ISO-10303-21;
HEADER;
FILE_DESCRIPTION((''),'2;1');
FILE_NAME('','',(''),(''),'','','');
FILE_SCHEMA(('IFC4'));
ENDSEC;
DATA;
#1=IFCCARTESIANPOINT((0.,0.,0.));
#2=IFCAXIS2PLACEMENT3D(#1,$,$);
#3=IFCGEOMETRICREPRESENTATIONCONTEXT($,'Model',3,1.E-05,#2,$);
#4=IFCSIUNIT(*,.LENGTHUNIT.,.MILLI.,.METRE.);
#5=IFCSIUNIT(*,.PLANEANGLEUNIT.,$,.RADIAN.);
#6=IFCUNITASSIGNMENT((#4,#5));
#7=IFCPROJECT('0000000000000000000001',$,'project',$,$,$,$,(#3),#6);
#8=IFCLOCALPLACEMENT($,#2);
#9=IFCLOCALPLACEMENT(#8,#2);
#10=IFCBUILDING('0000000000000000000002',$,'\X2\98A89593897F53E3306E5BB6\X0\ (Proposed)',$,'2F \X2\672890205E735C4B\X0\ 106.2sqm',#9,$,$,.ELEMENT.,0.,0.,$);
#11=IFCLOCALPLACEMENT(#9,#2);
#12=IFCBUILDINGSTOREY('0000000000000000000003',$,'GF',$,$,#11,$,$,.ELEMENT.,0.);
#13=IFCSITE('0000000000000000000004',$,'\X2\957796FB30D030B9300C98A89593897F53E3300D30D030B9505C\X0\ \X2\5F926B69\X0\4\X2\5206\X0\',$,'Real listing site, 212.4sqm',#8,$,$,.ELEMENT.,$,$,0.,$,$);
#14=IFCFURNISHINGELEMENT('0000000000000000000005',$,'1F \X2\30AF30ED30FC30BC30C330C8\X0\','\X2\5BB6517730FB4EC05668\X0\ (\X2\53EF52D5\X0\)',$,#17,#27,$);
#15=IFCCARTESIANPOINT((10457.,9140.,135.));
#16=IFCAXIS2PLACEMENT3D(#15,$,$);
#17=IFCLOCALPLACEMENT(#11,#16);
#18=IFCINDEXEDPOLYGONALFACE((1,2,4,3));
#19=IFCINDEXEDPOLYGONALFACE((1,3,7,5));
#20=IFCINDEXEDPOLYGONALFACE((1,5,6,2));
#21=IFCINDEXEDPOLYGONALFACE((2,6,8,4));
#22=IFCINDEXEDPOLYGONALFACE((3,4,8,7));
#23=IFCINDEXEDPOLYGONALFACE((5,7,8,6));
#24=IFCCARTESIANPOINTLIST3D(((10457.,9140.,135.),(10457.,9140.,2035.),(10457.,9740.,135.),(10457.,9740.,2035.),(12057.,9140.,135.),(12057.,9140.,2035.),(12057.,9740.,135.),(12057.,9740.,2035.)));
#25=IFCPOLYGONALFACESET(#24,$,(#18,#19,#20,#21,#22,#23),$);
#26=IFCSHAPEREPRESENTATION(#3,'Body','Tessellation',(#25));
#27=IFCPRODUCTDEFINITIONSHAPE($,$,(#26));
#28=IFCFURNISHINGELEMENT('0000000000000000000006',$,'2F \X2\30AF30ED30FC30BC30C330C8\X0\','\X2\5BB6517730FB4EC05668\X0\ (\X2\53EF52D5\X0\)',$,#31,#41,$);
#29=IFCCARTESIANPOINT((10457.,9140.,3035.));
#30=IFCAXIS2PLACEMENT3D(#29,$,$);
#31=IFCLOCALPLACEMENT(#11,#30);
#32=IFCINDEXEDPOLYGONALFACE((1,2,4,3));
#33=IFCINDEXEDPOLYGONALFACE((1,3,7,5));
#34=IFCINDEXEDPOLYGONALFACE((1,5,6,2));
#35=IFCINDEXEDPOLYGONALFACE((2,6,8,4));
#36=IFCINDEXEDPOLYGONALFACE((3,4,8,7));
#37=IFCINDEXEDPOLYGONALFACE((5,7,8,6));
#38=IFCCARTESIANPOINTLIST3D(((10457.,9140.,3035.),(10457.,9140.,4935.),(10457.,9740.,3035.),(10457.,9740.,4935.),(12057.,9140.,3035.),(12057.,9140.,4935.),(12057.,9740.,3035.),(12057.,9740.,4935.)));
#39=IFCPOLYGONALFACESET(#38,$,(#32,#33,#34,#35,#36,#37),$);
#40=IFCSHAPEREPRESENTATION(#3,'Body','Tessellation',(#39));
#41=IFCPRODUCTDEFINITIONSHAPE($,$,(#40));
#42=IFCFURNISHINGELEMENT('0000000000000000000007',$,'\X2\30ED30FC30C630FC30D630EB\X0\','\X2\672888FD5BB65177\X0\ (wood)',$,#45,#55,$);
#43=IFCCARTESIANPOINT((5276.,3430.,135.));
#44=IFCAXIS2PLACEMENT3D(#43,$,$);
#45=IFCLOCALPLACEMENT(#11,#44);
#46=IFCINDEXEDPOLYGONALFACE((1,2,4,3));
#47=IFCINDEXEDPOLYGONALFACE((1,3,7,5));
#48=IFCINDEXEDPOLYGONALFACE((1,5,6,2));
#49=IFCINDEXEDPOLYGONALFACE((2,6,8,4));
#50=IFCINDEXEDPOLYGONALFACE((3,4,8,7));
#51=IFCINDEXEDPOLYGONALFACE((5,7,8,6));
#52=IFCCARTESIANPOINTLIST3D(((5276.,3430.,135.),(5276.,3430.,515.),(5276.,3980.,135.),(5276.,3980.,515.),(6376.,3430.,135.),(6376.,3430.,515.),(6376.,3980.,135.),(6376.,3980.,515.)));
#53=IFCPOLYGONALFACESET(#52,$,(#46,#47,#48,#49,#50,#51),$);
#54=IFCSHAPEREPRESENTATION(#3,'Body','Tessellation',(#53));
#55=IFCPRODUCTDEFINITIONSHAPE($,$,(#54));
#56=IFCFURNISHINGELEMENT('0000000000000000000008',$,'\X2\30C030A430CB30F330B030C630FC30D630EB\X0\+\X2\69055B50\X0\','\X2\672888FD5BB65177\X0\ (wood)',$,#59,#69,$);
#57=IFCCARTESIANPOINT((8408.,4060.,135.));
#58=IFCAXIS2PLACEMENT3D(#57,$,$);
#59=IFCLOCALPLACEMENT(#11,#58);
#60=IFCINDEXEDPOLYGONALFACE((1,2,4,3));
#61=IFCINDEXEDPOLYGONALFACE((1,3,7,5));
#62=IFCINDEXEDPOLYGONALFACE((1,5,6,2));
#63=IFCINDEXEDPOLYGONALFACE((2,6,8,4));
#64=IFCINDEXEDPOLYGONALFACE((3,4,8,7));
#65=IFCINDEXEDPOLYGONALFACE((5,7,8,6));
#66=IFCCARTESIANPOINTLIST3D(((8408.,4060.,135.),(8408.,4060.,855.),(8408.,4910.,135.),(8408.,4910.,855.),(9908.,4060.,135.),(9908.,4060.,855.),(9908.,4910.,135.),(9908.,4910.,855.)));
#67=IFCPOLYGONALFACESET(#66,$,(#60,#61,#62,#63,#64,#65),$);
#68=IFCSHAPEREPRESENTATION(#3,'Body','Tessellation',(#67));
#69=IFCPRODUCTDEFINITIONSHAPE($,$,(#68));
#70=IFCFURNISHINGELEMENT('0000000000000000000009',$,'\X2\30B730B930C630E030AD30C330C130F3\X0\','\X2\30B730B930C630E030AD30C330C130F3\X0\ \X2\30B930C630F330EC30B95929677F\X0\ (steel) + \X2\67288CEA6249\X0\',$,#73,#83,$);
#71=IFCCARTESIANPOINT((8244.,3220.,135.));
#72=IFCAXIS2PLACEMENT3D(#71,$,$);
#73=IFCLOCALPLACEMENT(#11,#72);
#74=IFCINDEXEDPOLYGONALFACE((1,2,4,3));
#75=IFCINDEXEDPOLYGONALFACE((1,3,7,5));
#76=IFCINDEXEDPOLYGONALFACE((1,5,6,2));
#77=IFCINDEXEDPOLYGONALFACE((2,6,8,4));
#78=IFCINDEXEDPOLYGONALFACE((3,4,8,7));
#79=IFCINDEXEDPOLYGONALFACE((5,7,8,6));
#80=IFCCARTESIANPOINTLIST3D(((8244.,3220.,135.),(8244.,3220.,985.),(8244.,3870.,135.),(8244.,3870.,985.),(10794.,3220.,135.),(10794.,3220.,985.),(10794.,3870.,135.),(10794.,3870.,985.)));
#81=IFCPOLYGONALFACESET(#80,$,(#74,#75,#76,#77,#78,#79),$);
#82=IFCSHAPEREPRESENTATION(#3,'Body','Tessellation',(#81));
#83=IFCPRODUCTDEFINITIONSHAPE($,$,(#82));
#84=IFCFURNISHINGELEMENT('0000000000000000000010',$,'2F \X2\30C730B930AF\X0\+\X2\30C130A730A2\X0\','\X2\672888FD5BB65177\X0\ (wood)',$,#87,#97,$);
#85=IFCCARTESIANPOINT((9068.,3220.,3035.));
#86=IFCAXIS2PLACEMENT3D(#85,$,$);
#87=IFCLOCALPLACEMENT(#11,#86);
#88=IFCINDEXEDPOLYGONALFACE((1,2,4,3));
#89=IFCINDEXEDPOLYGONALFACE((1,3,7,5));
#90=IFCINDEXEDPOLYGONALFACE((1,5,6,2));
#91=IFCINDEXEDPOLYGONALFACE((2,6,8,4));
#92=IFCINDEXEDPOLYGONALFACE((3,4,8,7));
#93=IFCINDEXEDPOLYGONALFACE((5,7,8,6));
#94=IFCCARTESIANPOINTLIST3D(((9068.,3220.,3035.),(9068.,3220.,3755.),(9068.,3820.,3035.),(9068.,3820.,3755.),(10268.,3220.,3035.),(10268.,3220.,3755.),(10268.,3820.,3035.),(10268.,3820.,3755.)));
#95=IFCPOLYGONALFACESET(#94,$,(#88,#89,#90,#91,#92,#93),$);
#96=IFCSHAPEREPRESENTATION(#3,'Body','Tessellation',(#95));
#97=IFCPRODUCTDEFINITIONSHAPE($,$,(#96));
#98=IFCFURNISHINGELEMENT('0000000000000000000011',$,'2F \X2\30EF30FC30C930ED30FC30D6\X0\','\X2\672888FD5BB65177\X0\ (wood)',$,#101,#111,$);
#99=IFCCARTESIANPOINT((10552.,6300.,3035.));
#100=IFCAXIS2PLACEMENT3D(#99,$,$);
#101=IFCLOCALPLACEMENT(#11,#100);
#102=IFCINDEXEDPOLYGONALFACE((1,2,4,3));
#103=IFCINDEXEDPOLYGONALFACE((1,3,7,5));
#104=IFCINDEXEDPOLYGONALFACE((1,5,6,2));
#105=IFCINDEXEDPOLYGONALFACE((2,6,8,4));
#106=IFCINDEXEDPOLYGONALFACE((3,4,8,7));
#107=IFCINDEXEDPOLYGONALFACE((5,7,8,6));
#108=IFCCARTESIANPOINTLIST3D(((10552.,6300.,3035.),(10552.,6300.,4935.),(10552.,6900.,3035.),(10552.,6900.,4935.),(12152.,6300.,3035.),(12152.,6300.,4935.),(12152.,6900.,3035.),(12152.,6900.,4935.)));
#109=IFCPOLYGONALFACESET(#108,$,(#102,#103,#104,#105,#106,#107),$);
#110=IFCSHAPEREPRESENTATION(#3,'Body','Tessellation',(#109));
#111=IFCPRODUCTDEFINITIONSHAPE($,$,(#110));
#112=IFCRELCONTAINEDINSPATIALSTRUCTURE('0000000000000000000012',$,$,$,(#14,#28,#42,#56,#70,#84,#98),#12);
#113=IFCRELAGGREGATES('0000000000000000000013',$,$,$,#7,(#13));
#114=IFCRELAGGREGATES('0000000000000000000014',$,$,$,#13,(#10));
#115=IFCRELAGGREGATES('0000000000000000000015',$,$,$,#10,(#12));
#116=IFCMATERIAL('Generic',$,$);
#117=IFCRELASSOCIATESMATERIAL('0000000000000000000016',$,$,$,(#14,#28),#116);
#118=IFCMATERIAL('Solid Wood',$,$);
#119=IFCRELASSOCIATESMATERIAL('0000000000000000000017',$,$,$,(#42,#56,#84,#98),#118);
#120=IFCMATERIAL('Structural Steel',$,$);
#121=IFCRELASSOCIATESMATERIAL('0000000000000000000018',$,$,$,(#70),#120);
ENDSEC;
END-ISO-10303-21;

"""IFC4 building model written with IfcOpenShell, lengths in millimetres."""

from ifc_helpers import new_model, si_unit, frame, frame_2d, origin, place, context, project, spatial, rectangle, extrude, material, element, save


model = new_model("IFC4")

# Units and contexts
model_context = context("Model", 3, precision=1e-05, world=origin())
ifc_project = project(units=[si_unit("LENGTHUNIT", "METRE", prefix="MILLI"), si_unit("PLANEANGLEUNIT", "RADIAN")], contexts=[model_context])

# Site, building, storey
site_placement = place(None, origin())
site = spatial("IfcSite", under=ifc_project, at=site_placement, Name="長電バス「風間西口」バス停 徒歩4分", ObjectType="Real listing site, 212.4sqm", CompositionType="ELEMENT", RefElevation=0.0)
building_placement = place(site_placement, origin())
building = spatial("IfcBuilding", under=site, at=building_placement, Name="風間西口の家 (Proposed)", ObjectType="2F 木造平屋 106.2sqm", CompositionType="ELEMENT", ElevationOfRefHeight=0.0, ElevationOfTerrain=0.0)
storey_placement = place(building_placement, origin())
storey = spatial("IfcBuildingStorey", under=building, at=storey_placement, Name="GF", CompositionType="ELEMENT", Elevation=0.0)

# Shared definitions
ifc_material_1 = material(Name="Solid Wood")

# Shared definitions
ifc_material_2 = material(Name="Generic")

# Furnishing elements
furnishing_1_placement = place(storey_placement, frame((10457.0, 9140.0, 135.0)))
element("IfcFurnishingElement", 1, at=furnishing_1_placement, inside=storey, material=ifc_material_2, Name="1F クローゼット", Description="家具・什器 (可動)", context=model_context, shape_type="SweptSolid", body=[
    extrude(rectangle(XDim=1600.0, YDim=600.0, at=frame_2d((800.0, 300.0))), frame((10457.0, 9140.0, 135.0)), (0.0, 0.0, 1.0), 1900.0),
])
furnishing_2_placement = place(storey_placement, frame((10457.0, 9140.0, 3035.0)))
element("IfcFurnishingElement", 2, at=furnishing_2_placement, inside=storey, material=ifc_material_2, Name="2F クローゼット", Description="家具・什器 (可動)", context=model_context, shape_type="SweptSolid", body=[
    extrude(rectangle(XDim=1600.0, YDim=600.0, at=frame_2d((800.0, 300.0))), frame((10457.0, 9140.0, 3035.0)), (0.0, 0.0, 1.0), 1900.0),
])
furnishing_3_placement = place(storey_placement, frame((5276.0, 3430.0, 135.0)))
element("IfcFurnishingElement", 3, at=furnishing_3_placement, inside=storey, material=ifc_material_1, Name="ローテーブル", Description="木製家具 (wood)", context=model_context, shape_type="SweptSolid", body=[
    extrude(rectangle(XDim=1100.0, YDim=550.0, at=frame_2d((550.0, 275.0))), frame((5276.0, 3430.0, 135.0)), (0.0, 0.0, 1.0), 380.0),
])
furnishing_4_placement = place(storey_placement, frame((8408.0, 4060.0, 135.0)))
element("IfcFurnishingElement", 4, at=furnishing_4_placement, inside=storey, material=ifc_material_1, Name="ダイニングテーブル+椅子", Description="木製家具 (wood)", context=model_context, shape_type="SweptSolid", body=[
    extrude(rectangle(XDim=1500.0, YDim=850.0, at=frame_2d((750.0, 425.0))), frame((8408.0, 4060.0, 135.0)), (0.0, 0.0, 1.0), 720.0),
])
ifc_material_3 = material(Name="Structural Steel")
furnishing_5_placement = place(storey_placement, frame((8244.0, 3220.0, 135.0)))
element("IfcFurnishingElement", 5, at=furnishing_5_placement, inside=storey, material=ifc_material_3, Name="システムキッチン", Description="システムキッチン ステンレス天板 (steel) + 木質扉", context=model_context, shape_type="SweptSolid", body=[
    extrude(rectangle(XDim=2550.0, YDim=650.0, at=frame_2d((1275.0, 325.0))), frame((8244.0, 3220.0, 135.0)), (0.0, 0.0, 1.0), 850.0),
])
furnishing_6_placement = place(storey_placement, frame((9068.0, 3220.0, 3035.0)))
element("IfcFurnishingElement", 6, at=furnishing_6_placement, inside=storey, material=ifc_material_1, Name="2F デスク+チェア", Description="木製家具 (wood)", context=model_context, shape_type="SweptSolid", body=[
    extrude(rectangle(XDim=1200.0, YDim=600.0, at=frame_2d((600.0, 300.0))), frame((9068.0, 3220.0, 3035.0)), (0.0, 0.0, 1.0), 720.0),
])
furnishing_7_placement = place(storey_placement, frame((10552.0, 6300.0, 3035.0)))
element("IfcFurnishingElement", 7, at=furnishing_7_placement, inside=storey, material=ifc_material_1, Name="2F ワードローブ", Description="木製家具 (wood)", context=model_context, shape_type="SweptSolid", body=[
    extrude(rectangle(XDim=1600.0, YDim=600.0, at=frame_2d((800.0, 300.0))), frame((10552.0, 6300.0, 3035.0)), (0.0, 0.0, 1.0), 1900.0),
])

save(model, "model.ifc")
